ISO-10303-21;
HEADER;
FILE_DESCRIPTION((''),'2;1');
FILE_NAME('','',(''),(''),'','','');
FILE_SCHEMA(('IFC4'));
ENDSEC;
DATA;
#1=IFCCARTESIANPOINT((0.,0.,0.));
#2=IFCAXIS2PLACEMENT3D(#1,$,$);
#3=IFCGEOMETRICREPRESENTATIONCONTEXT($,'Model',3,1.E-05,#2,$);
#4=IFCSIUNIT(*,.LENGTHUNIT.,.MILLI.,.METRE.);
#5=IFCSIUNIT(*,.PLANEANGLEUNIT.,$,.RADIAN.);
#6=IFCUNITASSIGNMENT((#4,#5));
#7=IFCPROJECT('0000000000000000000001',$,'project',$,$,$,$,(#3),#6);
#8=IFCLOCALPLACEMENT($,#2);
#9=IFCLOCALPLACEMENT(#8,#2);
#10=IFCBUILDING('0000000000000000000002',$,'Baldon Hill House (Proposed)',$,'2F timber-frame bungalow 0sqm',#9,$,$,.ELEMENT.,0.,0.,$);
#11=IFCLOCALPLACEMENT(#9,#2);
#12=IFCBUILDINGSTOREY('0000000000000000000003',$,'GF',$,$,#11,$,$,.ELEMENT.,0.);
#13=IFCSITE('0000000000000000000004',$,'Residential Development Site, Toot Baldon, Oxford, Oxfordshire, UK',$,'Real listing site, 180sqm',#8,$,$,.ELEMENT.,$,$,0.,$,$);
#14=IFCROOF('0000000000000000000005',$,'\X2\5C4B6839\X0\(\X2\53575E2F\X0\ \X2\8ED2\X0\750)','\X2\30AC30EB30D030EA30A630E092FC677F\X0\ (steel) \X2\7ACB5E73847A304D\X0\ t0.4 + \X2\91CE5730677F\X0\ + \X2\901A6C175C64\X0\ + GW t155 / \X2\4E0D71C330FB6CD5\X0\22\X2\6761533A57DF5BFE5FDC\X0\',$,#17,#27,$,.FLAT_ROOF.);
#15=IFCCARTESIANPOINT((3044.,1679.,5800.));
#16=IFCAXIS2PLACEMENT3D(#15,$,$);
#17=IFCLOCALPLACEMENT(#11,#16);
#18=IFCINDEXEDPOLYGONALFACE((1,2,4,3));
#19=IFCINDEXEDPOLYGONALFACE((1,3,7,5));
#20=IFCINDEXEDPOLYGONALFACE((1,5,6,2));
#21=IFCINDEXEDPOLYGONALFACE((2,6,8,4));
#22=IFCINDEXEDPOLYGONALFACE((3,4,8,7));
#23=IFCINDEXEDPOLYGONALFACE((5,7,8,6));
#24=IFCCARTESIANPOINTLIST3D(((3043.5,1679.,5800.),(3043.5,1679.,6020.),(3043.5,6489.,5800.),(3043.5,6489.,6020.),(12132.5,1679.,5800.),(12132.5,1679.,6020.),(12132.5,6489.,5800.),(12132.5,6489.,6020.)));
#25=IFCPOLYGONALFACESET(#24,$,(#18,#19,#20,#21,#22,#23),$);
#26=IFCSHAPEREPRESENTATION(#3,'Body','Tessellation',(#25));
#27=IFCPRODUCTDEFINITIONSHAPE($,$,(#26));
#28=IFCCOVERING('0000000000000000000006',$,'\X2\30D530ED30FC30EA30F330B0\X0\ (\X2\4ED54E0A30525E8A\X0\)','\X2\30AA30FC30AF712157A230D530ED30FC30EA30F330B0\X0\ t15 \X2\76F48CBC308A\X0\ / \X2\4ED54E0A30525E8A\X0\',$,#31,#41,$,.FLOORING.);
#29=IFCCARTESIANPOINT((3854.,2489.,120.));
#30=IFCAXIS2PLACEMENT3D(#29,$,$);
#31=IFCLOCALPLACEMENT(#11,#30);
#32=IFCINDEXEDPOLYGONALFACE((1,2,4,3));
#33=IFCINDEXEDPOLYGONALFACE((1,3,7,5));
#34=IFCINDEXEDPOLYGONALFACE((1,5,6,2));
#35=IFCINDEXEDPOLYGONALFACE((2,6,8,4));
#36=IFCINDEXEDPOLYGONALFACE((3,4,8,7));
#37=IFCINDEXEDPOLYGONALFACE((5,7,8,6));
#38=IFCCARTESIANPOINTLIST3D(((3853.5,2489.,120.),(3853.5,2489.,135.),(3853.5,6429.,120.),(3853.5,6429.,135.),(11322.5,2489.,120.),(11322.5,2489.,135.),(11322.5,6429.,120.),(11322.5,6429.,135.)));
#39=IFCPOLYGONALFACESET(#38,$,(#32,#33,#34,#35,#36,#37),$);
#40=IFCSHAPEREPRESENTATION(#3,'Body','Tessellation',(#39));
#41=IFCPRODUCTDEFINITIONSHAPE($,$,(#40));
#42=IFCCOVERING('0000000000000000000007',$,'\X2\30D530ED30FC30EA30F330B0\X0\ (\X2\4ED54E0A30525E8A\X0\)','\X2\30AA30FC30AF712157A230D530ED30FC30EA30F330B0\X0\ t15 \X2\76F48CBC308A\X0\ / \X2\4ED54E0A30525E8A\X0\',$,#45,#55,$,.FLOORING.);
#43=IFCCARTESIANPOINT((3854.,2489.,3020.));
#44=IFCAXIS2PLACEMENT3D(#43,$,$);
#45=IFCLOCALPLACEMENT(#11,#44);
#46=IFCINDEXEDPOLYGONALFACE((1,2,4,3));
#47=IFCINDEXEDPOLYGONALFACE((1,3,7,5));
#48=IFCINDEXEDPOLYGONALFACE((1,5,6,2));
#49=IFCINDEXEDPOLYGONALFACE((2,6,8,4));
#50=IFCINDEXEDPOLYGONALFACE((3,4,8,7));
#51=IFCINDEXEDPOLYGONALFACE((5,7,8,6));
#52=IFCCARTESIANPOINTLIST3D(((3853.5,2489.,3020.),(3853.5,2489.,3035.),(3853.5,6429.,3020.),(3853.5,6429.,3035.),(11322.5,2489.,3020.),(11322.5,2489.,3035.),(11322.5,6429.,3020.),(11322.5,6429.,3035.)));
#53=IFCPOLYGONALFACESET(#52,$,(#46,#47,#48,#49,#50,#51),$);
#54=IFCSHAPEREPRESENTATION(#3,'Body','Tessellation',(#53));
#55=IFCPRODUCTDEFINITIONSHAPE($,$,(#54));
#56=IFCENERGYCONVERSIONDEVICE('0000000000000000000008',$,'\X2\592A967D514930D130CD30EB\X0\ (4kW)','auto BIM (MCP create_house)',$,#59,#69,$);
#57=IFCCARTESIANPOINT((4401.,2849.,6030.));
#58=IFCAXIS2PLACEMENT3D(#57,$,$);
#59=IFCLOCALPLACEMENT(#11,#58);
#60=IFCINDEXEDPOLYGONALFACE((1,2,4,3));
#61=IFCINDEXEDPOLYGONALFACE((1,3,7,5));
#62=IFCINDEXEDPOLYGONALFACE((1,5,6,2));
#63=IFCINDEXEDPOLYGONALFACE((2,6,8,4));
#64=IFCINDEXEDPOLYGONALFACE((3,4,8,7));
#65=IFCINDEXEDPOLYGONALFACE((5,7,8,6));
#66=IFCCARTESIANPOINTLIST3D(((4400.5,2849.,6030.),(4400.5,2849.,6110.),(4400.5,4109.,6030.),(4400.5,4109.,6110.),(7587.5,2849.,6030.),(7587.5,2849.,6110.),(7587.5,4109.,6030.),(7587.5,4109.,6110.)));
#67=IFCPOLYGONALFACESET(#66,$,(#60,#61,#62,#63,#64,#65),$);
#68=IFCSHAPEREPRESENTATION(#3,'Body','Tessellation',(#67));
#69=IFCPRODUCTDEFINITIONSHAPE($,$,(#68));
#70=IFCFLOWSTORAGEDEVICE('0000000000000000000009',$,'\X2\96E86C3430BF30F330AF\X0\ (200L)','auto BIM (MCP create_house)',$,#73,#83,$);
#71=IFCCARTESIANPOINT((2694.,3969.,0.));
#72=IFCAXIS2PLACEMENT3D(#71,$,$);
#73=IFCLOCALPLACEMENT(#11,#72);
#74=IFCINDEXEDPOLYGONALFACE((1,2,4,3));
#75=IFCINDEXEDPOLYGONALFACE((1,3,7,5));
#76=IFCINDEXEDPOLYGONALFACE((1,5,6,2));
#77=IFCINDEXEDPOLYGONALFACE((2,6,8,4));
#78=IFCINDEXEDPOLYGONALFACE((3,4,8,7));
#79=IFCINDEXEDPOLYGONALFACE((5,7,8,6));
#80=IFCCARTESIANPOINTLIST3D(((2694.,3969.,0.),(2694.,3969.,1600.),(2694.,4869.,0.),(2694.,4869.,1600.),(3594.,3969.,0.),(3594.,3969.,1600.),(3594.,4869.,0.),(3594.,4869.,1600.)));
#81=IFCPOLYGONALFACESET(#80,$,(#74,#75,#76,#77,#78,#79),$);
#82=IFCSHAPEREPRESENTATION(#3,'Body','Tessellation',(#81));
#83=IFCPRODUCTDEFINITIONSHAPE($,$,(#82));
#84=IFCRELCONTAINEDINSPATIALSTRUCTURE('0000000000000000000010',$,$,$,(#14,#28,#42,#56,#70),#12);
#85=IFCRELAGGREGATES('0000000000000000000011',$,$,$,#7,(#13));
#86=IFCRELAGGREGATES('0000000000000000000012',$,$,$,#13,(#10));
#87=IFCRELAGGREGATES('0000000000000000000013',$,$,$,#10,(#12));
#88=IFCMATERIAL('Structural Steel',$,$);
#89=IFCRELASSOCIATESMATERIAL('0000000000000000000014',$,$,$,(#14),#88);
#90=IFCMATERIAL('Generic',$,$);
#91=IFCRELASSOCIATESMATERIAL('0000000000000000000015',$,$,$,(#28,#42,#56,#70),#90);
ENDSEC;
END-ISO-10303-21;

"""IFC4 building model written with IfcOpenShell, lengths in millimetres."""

from ifc_helpers import new_model, si_unit, frame, frame_2d, origin, place, context, project, spatial, rectangle, extrude, material, element, save


model = new_model("IFC4")

# Units and contexts
model_context = context("Model", 3, precision=1e-05, world=origin())
ifc_project = project(units=[si_unit("LENGTHUNIT", "METRE", prefix="MILLI"), si_unit("PLANEANGLEUNIT", "RADIAN")], contexts=[model_context])

# Site, building, storey
site_placement = place(None, origin())
site = spatial("IfcSite", under=ifc_project, at=site_placement, Name="Residential Development Site, Toot Baldon, Oxford, Oxfordshire, UK", ObjectType="Real listing site, 180sqm", CompositionType="ELEMENT", RefElevation=0.0)
building_placement = place(site_placement, origin())
building = spatial("IfcBuilding", under=site, at=building_placement, Name="Baldon Hill House (Proposed)", ObjectType="2F timber-frame bungalow 0sqm", CompositionType="ELEMENT", ElevationOfRefHeight=0.0, ElevationOfTerrain=0.0)
storey_placement = place(building_placement, origin())
storey = spatial("IfcBuildingStorey", under=building, at=storey_placement, Name="GF", CompositionType="ELEMENT", Elevation=0.0)

# Roof
ifc_material_1 = material(Name="Structural Steel")
for number, where, name in (
    (1, (3044.0, 1679.0, 5800.0), "屋根(南帯 軒750)"),
):
    element("IfcRoof", number, at=place(storey_placement, frame(where)), inside=storey, material=ifc_material_1, Name=name, Description="ガルバリウム鋼板 (steel) 立平葺き t0.4 + 野地板 + 通気層 + GW t155 / 不燃・法22条区域対応", PredefinedType="FLAT_ROOF", context=model_context, shape_type="SweptSolid", body=[
        extrude(rectangle(XDim=9089.0, YDim=4810.0, at=frame_2d((4544.0, 2405.0))), frame((3044.0, 1679.0, 5800.0)), (0.0, 0.0, 1.0), 220.0),
    ])

# Coverings
ifc_material_2 = material(Name="Generic")
covering_1_placement = place(storey_placement, frame((3854.0, 2489.0, 120.0)))
element("IfcCovering", 2, at=covering_1_placement, inside=storey, material=ifc_material_2, Name="フローリング (仕上げ床)", Description="オーク無垢フローリング t15 直貼り / 仕上げ床", PredefinedType="FLOORING", context=model_context, shape_type="SweptSolid", body=[
    extrude(rectangle(XDim=7469.0, YDim=3940.0, at=frame_2d((3734.0, 1970.0))), frame((3854.0, 2489.0, 120.0)), (0.0, 0.0, 1.0), 15.0),
])
covering_2_placement = place(storey_placement, frame((3854.0, 2489.0, 3020.0)))
element("IfcCovering", 3, at=covering_2_placement, inside=storey, material=ifc_material_2, Name="フローリング (仕上げ床)", Description="オーク無垢フローリング t15 直貼り / 仕上げ床", PredefinedType="FLOORING", context=model_context, shape_type="SweptSolid", body=[
    extrude(rectangle(XDim=7469.0, YDim=3940.0, at=frame_2d((3734.0, 1970.0))), frame((3854.0, 2489.0, 3020.0)), (0.0, 0.0, 1.0), 15.0),
])

# Energy conversion device
energy_conversion_device_placement = place(storey_placement, frame((4401.0, 2849.0, 6030.0)))
element("IfcEnergyConversionDevice", 4, at=energy_conversion_device_placement, inside=storey, material=ifc_material_2, Name="太陽光パネル (4kW)", Description="auto BIM (MCP create_house)", context=model_context, shape_type="SweptSolid", body=[
    extrude(rectangle(XDim=3187.0, YDim=1260.0, at=frame_2d((1593.0, 630.0))), frame((4401.0, 2849.0, 6030.0)), (0.0, 0.0, 1.0), 80.0),
])

# Flow storage device
flow_storage_device_placement = place(storey_placement, frame((2694.0, 3969.0, 0.0)))
element("IfcFlowStorageDevice", 5, at=flow_storage_device_placement, inside=storey, material=ifc_material_2, Name="雨水タンク (200L)", Description="auto BIM (MCP create_house)", context=model_context, shape_type="SweptSolid", body=[
    extrude(rectangle(XDim=900.0, YDim=900.0, at=frame_2d((450.0, 450.0))), frame((2694.0, 3969.0, 0.0)), (0.0, 0.0, 1.0), 1600.0),
])

save(model, "model.ifc")
